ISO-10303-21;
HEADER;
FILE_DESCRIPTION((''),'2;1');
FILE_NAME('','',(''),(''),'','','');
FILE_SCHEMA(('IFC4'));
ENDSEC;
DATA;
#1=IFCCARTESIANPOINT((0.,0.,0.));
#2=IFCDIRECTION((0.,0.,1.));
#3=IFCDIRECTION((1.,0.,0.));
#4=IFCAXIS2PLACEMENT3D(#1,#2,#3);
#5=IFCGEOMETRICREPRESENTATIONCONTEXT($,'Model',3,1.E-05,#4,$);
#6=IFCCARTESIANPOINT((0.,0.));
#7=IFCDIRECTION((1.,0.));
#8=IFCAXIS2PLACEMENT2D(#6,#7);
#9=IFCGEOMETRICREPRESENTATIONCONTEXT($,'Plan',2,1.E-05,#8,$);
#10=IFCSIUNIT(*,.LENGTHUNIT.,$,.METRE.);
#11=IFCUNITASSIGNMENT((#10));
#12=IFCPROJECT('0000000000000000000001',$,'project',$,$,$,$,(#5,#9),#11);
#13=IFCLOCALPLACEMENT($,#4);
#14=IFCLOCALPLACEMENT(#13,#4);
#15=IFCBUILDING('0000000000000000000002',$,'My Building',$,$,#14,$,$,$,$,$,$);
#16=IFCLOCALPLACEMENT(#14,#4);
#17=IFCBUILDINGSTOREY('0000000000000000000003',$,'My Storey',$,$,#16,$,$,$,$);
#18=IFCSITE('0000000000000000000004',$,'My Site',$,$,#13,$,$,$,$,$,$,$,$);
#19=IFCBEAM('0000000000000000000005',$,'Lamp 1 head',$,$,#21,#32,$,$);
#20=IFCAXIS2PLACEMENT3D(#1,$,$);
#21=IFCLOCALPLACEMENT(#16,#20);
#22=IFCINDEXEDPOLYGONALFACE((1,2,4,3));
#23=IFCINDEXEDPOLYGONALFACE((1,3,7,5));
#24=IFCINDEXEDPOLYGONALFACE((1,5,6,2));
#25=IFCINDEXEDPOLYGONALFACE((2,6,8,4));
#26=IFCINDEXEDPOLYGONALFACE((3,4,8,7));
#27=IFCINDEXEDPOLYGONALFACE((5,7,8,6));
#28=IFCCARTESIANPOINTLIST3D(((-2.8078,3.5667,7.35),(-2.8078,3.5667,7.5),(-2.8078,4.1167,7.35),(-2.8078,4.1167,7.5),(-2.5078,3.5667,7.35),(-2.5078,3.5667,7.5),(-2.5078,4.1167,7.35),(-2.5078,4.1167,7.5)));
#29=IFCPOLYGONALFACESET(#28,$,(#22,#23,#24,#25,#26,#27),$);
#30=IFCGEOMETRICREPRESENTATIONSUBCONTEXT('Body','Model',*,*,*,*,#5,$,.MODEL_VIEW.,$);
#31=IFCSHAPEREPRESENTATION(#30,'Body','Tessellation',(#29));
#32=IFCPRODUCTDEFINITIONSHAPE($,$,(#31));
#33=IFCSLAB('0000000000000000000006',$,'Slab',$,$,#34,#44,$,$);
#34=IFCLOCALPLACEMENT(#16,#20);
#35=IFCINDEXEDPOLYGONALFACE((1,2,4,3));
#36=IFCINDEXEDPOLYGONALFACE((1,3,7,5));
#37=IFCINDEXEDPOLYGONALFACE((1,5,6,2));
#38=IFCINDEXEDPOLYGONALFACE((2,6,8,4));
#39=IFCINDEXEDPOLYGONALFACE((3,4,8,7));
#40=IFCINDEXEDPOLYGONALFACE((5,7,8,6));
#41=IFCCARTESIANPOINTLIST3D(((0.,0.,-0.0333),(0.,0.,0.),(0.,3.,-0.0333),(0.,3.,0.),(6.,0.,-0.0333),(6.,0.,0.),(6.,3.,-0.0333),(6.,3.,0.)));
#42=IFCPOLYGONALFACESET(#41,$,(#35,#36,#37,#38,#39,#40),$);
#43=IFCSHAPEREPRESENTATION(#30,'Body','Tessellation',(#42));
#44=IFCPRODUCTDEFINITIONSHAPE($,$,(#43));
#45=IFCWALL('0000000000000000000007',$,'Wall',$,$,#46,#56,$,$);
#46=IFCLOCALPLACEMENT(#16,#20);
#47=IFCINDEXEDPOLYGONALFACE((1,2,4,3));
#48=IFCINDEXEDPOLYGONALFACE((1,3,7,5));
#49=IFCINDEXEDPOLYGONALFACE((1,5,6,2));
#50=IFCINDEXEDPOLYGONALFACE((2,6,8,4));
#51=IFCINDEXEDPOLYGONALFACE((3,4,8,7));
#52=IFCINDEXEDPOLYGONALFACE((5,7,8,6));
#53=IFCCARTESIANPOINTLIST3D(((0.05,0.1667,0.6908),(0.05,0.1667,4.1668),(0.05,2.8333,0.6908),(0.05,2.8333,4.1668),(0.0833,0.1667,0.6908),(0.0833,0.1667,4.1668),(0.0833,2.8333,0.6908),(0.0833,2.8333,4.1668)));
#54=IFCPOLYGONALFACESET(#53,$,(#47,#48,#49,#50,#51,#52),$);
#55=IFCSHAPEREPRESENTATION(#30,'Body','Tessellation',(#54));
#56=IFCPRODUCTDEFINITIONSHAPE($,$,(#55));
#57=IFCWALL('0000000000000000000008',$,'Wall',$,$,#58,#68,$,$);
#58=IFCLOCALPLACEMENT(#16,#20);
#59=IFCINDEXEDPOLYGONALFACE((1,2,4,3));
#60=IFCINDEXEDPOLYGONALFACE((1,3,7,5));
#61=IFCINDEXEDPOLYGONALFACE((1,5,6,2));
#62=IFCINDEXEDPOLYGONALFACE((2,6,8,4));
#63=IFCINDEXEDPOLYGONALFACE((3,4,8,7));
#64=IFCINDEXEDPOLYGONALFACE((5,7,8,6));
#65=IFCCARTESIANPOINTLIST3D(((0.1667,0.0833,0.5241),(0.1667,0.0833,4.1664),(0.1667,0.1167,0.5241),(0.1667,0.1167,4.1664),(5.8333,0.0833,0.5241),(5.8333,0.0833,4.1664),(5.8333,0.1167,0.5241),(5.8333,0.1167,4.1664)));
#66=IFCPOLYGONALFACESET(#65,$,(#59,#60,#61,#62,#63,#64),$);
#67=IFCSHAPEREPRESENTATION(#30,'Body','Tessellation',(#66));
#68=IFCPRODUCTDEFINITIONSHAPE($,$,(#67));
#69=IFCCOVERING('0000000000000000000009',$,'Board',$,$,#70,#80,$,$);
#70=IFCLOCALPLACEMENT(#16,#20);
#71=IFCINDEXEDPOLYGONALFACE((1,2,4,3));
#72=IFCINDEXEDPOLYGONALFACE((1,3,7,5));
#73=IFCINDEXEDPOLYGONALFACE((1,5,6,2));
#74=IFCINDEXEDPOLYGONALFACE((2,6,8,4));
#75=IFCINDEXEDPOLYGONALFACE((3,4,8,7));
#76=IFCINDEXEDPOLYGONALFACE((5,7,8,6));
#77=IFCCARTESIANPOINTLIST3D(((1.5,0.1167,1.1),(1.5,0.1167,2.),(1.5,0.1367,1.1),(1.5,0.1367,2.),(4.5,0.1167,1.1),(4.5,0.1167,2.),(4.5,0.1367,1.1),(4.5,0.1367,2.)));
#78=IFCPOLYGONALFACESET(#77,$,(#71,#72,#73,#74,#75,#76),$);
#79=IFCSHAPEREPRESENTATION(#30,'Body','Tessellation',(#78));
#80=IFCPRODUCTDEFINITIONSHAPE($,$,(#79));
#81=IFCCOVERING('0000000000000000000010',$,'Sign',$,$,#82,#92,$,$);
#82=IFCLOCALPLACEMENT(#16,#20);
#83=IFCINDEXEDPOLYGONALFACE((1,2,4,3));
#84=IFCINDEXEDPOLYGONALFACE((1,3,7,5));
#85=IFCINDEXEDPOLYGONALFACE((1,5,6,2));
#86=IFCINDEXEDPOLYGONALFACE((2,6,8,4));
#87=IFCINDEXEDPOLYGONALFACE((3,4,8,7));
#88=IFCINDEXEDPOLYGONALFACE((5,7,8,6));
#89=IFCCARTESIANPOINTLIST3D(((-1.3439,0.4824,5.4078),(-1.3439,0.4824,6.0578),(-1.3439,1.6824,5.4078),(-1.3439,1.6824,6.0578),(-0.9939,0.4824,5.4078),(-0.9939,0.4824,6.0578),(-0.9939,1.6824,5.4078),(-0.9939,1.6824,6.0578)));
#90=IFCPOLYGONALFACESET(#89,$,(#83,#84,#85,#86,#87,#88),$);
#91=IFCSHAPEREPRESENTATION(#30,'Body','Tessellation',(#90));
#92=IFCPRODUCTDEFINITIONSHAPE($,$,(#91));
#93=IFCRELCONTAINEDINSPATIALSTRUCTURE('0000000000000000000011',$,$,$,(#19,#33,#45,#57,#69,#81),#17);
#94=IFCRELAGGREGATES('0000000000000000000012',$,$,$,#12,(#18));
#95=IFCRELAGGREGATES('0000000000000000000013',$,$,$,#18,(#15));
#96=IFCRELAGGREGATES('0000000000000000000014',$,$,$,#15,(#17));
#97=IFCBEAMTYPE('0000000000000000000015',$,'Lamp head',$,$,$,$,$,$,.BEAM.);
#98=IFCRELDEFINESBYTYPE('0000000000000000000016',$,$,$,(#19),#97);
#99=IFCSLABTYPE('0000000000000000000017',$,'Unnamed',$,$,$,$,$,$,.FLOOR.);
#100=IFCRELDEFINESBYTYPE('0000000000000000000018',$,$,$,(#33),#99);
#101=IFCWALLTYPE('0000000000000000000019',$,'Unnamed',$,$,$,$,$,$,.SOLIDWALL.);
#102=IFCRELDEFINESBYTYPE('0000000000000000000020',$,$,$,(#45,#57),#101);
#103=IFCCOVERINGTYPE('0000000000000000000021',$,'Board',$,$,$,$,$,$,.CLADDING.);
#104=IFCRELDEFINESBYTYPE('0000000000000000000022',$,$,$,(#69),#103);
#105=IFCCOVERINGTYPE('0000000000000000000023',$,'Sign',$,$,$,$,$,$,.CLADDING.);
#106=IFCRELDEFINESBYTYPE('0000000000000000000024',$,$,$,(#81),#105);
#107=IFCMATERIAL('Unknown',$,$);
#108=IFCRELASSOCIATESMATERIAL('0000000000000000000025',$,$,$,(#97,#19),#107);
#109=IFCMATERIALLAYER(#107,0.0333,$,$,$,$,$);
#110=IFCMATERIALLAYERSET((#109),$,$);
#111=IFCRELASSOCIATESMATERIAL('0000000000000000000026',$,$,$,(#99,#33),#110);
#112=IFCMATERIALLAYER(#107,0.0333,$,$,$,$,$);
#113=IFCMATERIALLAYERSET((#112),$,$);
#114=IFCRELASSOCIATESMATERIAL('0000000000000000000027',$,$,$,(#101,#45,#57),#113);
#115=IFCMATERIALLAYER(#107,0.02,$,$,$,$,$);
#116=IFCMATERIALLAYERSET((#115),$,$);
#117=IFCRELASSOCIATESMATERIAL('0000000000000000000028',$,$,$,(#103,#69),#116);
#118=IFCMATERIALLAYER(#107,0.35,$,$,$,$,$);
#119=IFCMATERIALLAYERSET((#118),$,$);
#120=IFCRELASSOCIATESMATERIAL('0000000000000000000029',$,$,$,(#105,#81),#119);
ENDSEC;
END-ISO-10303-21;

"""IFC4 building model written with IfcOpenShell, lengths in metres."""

from ifc_helpers import new_model, si_unit, frame, origin_with_axes, origin_2d_with_axis, place, context, subcontext, project, spatial, line, indexed_curve, rectangle, outline, extrude, material, layer, layer_set, layer_usage, material_profile, profile_set, profile_usage, type_object, element, save


model = new_model("IFC4")

# Units and contexts
model_context = context("Model", 3, precision=1e-05, world=origin_with_axes())
plan_context = context("Plan", 2, precision=1e-05, world=origin_2d_with_axis())
body_context = subcontext(model_context, "Body", "Model", "MODEL_VIEW")
ifc_project = project(units=[si_unit("LENGTHUNIT", "METRE")], contexts=[model_context, plan_context])

# Site, building, storey
site_placement = place(None, origin_with_axes())
site = spatial("IfcSite", under=ifc_project, at=site_placement, Name="My Site")
building_placement = place(site_placement, origin_with_axes())
building = spatial("IfcBuilding", under=site, at=building_placement, Name="My Building")
storey_placement = place(building_placement, origin_with_axes())
storey = spatial("IfcBuildingStorey", under=building, at=storey_placement, Name="My Storey")

# Shared definitions
ifc_material = material(Name="Unknown")

# Beam
ifc_material_profile_1 = material_profile(ifc_material, rectangle(XDim=0.3, YDim=0.15))
ifc_profile_set_1 = profile_set([ifc_material_profile_1])
ifc_profile_usage_1 = profile_usage(ifc_profile_set_1, cardinal=5)
beam_type_1 = type_object("IfcBeamType", Name="Lamp head", PredefinedType="BEAM", material=ifc_profile_set_1)
beam_1_placement = place(storey_placement, frame((-2.6578, 3.5667, 7.425), z_axis=(0.0, 1.0, 0.0), x_axis=(1.0, 0.0, 0.0)))
element("IfcBeam", 1, at=beam_1_placement, inside=storey, type_object=beam_type_1, material=ifc_profile_usage_1, Name="Lamp 1 head", context=body_context, shape_type="SweptSolid", body=[
    extrude(rectangle(XDim=0.3, YDim=0.15), origin_with_axes(), (0.0, 0.0, 1.0), 0.55),
])

# Slab
ifc_layer_1 = layer(ifc_material, 0.0333)
ifc_layer_set_1 = layer_set([ifc_layer_1])
ifc_layer_usage_1 = layer_usage(ifc_layer_set_1, "AXIS3", "POSITIVE", -0.0333)
slab_type = type_object("IfcSlabType", Name="Unnamed", PredefinedType="FLOOR", material=ifc_layer_set_1)
slab_placement = place(storey_placement, frame((0.0, 3.0, 0.0), z_axis=(0.0, 0.0, 1.0), x_axis=(1.0, 0.0, 0.0)))
element("IfcSlab", 2, at=slab_placement, inside=storey, type_object=slab_type, material=ifc_layer_usage_1, Name="Slab", context=body_context, shape_type="SweptSolid", body=[
    extrude(outline(indexed_curve([(0.0, 0.0), (6.0, 0.0), (6.0, -3.0), (0.0, -3.0), (0.0, 0.0)])), frame((0.0, 0.0, -0.0333), z_axis=(0.0, 0.0, 1.0), x_axis=(1.0, 0.0, 0.0)), (0.0, 0.0, 1.0), 0.0333),
])

# Walls
ifc_layer_2 = layer(ifc_material, 0.0333)
ifc_layer_set_2 = layer_set([ifc_layer_2])
ifc_layer_usage_2 = layer_usage(ifc_layer_set_2, "AXIS2", "POSITIVE", 0.0)
wall_type = type_object("IfcWallType", Name="Unnamed", PredefinedType="SOLIDWALL", material=ifc_layer_set_2)
wall_1_placement = place(storey_placement, frame((0.0833, 0.1667, 0.6908), z_axis=(0.0, 0.0, 1.0), x_axis=(-0.000003, 1.0, 0.0)))
element("IfcWall", 3, at=wall_1_placement, inside=storey, type_object=wall_type, material=ifc_layer_usage_2, Name="Wall", context=body_context, shape_type="SweptSolid", body=[
    extrude(outline(indexed_curve([(0.0, 0.0), (0.0, 0.0333), (2.6667, 0.0333), (2.6667, 0.0)], segments=[line(1, 2, 3, 4, 1)])), origin_with_axes(), (0.0, 0.0, 1.0), 3.476),
])
ifc_layer_usage_3 = layer_usage(ifc_layer_set_2, "AXIS2", "POSITIVE", 0.0)
wall_2_placement = place(storey_placement, frame((0.1667, 0.0833, 0.5241), z_axis=(0.0, 0.0, 1.0), x_axis=(1.0, 0.0, 0.0)))
element("IfcWall", 4, at=wall_2_placement, inside=storey, type_object=wall_type, material=ifc_layer_usage_3, Name="Wall", context=body_context, shape_type="SweptSolid", body=[
    extrude(outline(indexed_curve([(0.0, 0.0), (0.0, 0.0333), (5.6667, 0.0333), (5.6667, 0.0)], segments=[line(1, 2, 3, 4, 1)])), origin_with_axes(), (0.0, 0.0, 1.0), 3.6423),
])

# Coverings
ifc_layer_3 = layer(ifc_material, 0.02)
ifc_layer_set_3 = layer_set([ifc_layer_3])
ifc_layer_usage_4 = layer_usage(ifc_layer_set_3, "AXIS2", "POSITIVE", 0.0)
covering_type_1 = type_object("IfcCoveringType", Name="Board", PredefinedType="CLADDING", material=ifc_layer_set_3)
covering_1_placement = place(storey_placement, frame((1.5, 0.1167, 1.1), z_axis=(0.0, 0.0, 1.0), x_axis=(1.0, 0.0, 0.0)))
element("IfcCovering", 5, at=covering_1_placement, inside=storey, type_object=covering_type_1, material=ifc_layer_usage_4, Name="Board", context=body_context, shape_type="SweptSolid", body=[
    extrude(outline(indexed_curve([(0.0, 0.0), (0.0, 0.02), (3.0, 0.02), (3.0, 0.0)], segments=[line(1, 2, 3, 4, 1)])), origin_with_axes(), (0.0, 0.0, 1.0), 0.9),
])
ifc_layer_4 = layer(ifc_material, 0.35)
ifc_layer_set_4 = layer_set([ifc_layer_4])
ifc_layer_usage_5 = layer_usage(ifc_layer_set_4, "AXIS2", "POSITIVE", 0.0)
covering_type_2 = type_object("IfcCoveringType", Name="Sign", PredefinedType="CLADDING", material=ifc_layer_set_4)
covering_2_placement = place(storey_placement, frame((-0.9939, 0.4824, 5.4078), z_axis=(0.0, 0.0, 1.0), x_axis=(0.0, 1.0, 0.0)))
element("IfcCovering", 6, at=covering_2_placement, inside=storey, type_object=covering_type_2, material=ifc_layer_usage_5, Name="Sign", context=body_context, shape_type="SweptSolid", body=[
    extrude(outline(indexed_curve([(0.0, 0.0), (0.0, 0.35), (1.2, 0.35), (1.2, 0.0)], segments=[line(1, 2, 3, 4, 1)])), origin_with_axes(), (0.0, 0.0, 1.0), 0.65),
])

save(model, "model.ifc")
